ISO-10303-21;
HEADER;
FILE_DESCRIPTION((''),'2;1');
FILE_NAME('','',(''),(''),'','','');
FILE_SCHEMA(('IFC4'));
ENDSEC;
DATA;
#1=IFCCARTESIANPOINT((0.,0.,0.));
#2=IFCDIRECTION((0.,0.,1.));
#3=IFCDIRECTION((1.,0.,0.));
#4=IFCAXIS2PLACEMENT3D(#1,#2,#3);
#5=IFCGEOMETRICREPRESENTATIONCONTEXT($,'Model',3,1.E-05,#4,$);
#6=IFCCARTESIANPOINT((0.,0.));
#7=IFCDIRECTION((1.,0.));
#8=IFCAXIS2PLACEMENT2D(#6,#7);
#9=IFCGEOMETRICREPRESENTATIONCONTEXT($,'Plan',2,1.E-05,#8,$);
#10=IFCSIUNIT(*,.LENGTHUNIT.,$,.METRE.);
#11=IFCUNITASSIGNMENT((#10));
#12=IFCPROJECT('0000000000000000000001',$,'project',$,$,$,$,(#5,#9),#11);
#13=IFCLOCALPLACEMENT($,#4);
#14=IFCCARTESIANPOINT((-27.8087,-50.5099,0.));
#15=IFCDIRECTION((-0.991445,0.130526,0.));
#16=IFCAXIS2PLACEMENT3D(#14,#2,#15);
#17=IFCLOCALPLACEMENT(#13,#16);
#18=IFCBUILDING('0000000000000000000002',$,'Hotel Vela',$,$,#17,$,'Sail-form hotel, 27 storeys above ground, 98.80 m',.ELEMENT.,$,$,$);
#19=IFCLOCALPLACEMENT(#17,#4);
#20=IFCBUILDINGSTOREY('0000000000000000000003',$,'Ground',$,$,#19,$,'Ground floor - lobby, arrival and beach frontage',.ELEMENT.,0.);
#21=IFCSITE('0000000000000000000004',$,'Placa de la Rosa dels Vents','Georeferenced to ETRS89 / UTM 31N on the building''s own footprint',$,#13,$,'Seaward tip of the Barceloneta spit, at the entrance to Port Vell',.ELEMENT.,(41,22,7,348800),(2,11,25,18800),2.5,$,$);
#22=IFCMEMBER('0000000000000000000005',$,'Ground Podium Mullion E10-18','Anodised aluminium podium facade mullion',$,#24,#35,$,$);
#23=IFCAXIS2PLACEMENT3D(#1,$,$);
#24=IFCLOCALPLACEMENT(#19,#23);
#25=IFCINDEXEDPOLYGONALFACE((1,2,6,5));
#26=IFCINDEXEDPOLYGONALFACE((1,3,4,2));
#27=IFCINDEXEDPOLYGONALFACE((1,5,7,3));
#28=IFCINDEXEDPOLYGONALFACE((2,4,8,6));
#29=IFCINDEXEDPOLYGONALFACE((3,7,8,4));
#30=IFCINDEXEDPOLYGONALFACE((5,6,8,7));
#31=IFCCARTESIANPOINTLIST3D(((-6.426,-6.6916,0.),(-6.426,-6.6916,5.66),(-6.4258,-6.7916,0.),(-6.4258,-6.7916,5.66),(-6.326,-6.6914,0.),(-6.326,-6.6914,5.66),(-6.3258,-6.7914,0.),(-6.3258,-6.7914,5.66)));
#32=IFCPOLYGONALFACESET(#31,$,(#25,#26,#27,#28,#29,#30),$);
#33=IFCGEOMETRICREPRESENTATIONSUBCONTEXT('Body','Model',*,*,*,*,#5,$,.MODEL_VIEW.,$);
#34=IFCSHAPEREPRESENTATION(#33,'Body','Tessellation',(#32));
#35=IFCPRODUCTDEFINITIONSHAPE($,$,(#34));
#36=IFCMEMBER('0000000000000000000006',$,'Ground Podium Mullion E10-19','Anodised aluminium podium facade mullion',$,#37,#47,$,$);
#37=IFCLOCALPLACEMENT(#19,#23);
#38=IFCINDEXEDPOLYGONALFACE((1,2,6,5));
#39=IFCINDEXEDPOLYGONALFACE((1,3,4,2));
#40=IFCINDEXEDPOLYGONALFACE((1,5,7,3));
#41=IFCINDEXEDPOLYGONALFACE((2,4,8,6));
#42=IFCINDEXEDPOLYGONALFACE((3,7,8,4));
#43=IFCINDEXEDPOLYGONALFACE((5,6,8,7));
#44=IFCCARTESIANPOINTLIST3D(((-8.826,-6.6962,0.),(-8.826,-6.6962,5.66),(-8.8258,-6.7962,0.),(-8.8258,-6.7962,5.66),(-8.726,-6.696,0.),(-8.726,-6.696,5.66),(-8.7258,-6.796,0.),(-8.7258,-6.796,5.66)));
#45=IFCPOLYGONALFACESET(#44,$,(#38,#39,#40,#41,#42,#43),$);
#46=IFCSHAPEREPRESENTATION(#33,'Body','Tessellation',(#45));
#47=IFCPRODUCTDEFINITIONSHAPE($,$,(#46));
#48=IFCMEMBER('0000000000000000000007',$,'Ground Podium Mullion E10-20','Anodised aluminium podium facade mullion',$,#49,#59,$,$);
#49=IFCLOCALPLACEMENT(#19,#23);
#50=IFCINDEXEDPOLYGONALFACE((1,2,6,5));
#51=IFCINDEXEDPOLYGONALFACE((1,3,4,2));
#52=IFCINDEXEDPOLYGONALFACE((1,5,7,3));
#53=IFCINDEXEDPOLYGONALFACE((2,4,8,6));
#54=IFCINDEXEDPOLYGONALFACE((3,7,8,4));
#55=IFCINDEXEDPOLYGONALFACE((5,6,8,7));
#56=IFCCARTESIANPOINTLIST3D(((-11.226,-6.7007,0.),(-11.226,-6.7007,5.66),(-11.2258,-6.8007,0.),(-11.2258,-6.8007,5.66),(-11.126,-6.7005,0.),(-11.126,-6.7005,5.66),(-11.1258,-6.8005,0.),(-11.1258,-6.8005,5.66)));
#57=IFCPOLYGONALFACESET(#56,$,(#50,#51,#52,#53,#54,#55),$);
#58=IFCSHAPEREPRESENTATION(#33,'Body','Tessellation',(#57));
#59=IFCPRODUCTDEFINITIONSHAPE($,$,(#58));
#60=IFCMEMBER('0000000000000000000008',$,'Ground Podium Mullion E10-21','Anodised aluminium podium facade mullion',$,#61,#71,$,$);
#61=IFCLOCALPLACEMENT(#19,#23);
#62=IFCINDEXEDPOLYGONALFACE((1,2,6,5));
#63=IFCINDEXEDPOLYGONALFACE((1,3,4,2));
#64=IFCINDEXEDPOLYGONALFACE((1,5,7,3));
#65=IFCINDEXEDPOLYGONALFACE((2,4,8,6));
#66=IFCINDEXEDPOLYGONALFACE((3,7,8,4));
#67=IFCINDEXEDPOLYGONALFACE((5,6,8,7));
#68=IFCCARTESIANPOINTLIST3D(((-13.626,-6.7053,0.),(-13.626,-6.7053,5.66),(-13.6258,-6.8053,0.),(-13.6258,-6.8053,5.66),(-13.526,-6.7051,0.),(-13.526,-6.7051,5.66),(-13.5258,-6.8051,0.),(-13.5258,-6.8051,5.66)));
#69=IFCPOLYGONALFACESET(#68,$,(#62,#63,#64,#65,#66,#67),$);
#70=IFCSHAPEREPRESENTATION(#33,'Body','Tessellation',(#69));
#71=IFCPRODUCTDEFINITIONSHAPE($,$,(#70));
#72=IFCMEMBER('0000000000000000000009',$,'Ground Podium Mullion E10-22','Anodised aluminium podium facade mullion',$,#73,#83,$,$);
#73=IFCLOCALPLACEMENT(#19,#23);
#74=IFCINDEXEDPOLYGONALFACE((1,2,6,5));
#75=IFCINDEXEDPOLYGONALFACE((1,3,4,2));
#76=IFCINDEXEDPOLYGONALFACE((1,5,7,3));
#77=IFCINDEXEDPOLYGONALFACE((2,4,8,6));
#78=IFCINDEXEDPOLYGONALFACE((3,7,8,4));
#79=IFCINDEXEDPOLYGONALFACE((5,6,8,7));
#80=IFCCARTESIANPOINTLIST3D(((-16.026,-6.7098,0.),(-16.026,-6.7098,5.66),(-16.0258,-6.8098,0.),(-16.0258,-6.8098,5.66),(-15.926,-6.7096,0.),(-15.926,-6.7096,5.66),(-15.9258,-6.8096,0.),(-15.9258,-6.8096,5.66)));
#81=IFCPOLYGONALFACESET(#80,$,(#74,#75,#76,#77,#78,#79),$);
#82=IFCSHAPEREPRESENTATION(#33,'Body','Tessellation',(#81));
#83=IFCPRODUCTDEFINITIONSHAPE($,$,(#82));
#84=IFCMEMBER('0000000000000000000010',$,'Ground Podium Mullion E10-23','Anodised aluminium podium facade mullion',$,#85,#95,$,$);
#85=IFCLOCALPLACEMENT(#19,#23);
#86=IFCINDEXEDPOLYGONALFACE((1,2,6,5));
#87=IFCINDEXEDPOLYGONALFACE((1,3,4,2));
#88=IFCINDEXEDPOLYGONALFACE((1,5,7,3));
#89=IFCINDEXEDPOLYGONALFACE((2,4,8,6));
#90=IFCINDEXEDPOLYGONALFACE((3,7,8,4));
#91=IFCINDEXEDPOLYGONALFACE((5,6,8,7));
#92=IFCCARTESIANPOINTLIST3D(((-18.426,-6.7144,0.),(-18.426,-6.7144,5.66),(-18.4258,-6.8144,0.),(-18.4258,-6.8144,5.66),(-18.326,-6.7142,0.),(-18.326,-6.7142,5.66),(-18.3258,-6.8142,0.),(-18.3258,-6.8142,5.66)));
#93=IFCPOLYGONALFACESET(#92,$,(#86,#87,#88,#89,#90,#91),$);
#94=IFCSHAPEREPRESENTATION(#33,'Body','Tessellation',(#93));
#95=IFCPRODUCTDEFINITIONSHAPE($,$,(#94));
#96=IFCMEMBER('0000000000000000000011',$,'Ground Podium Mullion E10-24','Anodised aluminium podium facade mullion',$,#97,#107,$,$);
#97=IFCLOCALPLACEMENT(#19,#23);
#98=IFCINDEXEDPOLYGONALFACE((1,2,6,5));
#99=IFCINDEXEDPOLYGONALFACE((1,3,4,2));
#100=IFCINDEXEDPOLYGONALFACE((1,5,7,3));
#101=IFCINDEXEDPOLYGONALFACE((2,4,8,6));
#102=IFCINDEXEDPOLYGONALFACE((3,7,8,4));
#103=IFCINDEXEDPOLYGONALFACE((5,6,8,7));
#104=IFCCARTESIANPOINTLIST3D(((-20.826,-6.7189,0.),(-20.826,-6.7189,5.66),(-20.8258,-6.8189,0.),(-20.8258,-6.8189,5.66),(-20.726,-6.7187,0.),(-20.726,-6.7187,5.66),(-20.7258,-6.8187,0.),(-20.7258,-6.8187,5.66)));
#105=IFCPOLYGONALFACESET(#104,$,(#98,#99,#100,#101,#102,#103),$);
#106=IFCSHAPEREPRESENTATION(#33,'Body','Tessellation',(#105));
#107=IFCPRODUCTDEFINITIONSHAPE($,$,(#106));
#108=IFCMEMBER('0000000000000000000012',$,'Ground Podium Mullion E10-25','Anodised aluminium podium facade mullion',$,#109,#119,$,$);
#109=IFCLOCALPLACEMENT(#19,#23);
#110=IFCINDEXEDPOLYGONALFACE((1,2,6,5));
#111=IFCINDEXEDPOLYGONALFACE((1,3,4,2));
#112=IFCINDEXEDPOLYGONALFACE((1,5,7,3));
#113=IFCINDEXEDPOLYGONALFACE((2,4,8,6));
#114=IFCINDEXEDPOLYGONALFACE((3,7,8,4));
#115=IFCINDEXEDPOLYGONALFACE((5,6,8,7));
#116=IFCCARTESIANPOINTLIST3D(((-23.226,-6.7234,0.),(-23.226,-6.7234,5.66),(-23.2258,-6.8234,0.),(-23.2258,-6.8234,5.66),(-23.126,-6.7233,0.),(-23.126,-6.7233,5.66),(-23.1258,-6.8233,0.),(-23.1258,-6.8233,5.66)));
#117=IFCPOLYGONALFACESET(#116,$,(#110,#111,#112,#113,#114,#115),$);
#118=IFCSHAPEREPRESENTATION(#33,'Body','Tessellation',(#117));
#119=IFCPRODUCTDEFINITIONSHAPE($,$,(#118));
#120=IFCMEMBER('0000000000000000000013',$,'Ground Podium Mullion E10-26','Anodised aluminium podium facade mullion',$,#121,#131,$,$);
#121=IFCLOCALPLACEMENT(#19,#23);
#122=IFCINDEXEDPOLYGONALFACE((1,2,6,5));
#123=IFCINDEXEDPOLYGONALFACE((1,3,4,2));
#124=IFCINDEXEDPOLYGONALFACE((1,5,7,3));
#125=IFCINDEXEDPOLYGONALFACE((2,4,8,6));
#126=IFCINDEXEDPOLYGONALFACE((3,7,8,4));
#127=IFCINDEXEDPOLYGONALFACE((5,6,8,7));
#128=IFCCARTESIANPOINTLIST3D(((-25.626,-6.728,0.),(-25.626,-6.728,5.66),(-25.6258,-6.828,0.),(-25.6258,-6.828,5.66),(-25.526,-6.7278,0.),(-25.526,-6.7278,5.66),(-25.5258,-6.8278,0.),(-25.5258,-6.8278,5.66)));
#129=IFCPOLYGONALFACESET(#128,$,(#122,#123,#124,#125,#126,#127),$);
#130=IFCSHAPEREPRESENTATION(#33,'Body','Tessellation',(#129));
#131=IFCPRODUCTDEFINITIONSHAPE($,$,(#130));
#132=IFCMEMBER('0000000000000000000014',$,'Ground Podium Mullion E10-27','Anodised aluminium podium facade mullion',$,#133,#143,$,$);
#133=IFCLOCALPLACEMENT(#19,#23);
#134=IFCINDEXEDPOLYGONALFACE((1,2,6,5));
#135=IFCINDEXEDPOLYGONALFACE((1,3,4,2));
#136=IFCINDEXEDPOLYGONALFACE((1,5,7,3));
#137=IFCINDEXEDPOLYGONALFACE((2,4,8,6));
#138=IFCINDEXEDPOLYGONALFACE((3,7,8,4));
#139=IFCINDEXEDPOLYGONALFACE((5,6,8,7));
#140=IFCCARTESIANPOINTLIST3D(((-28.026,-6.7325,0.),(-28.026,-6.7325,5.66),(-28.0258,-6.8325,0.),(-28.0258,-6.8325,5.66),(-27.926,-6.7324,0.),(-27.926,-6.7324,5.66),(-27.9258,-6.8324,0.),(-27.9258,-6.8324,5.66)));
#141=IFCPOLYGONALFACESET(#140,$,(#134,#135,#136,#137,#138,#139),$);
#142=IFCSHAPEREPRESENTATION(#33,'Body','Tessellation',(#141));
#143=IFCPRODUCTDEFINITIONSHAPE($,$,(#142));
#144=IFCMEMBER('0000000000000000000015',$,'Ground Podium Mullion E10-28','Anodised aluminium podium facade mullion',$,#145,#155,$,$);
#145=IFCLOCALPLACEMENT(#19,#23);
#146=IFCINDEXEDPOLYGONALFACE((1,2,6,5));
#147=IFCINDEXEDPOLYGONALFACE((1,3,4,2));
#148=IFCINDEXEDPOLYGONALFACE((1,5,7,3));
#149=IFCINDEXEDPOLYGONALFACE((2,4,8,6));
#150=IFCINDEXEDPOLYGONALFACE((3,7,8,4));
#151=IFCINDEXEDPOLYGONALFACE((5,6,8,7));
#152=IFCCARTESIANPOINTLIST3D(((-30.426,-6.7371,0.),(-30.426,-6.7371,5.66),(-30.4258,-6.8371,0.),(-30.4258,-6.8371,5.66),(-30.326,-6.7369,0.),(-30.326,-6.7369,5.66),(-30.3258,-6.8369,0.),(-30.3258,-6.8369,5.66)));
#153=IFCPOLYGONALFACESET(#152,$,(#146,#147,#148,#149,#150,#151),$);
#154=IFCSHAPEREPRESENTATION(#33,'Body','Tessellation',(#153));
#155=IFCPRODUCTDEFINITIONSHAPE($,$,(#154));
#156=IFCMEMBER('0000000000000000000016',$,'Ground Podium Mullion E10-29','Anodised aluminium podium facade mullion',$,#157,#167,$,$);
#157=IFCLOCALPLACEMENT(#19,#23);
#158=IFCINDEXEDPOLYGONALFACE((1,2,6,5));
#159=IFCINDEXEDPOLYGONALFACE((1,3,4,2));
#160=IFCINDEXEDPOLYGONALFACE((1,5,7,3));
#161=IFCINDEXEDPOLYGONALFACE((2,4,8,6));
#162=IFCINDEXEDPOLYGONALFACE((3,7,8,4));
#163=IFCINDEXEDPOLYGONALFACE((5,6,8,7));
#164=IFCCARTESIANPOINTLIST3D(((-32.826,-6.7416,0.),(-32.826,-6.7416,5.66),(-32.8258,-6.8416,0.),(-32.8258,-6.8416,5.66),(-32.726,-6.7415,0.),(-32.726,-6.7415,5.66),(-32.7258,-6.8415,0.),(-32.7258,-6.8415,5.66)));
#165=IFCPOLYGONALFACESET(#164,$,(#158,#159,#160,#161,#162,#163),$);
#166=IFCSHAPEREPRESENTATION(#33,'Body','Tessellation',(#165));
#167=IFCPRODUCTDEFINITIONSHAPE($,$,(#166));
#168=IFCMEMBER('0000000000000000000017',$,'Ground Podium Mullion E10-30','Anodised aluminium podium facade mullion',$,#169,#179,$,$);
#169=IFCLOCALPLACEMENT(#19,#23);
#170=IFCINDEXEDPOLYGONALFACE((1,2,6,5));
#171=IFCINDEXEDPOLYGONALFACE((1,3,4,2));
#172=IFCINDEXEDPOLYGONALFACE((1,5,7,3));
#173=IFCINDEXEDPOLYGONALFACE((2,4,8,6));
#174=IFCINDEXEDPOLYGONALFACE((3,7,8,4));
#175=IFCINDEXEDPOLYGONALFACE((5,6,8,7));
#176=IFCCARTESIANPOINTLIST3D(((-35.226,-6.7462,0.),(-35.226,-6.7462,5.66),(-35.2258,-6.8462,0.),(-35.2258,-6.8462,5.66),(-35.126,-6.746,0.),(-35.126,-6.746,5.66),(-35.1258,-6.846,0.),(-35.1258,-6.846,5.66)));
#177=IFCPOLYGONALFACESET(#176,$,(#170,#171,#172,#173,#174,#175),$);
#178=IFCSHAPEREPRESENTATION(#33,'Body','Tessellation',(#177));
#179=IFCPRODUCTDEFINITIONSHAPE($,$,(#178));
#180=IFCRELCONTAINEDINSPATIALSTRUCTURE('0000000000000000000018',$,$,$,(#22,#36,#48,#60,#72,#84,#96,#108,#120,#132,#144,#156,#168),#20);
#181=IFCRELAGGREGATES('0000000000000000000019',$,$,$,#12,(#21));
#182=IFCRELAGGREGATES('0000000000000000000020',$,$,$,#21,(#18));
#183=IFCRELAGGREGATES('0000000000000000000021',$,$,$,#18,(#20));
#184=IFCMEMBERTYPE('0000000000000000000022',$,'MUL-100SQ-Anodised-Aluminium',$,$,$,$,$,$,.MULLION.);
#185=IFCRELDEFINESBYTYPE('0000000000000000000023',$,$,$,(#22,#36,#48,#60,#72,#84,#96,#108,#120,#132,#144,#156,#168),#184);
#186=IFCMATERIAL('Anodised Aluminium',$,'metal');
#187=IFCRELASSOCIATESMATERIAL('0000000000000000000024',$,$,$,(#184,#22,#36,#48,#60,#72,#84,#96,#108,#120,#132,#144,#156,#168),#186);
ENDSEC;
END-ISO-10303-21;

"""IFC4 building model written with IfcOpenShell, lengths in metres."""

from ifc_helpers import new_model, si_unit, frame, origin_with_axes, origin_2d_with_axis, place, context, subcontext, project, spatial, line, indexed_curve, rectangle, outline, extrude, material, material_profile, profile_set, profile_usage, type_object, element, save


model = new_model("IFC4")

# Units and contexts
model_context = context("Model", 3, precision=1e-05, world=origin_with_axes())
plan_context = context("Plan", 2, precision=1e-05, world=origin_2d_with_axis())
body_context = subcontext(model_context, "Body", "Model", "MODEL_VIEW")
ifc_project = project(units=[si_unit("LENGTHUNIT", "METRE")], contexts=[model_context, plan_context])

# Site, building, storey
site_placement = place(None, origin_with_axes())
site = spatial("IfcSite", under=ifc_project, at=site_placement, Name="Placa de la Rosa dels Vents", Description="Georeferenced to ETRS89 / UTM 31N on the building's own footprint", LongName="Seaward tip of the Barceloneta spit, at the entrance to Port Vell", CompositionType="ELEMENT", RefLatitude=(41, 22, 7, 348800), RefLongitude=(2, 11, 25, 18800), RefElevation=2.5)
building_placement = place(site_placement, frame((-27.8087, -50.5099, 0.0), z_axis=(0.0, 0.0, 1.0), x_axis=(-0.991445, 0.130526, 0.0)))
building = spatial("IfcBuilding", under=site, at=building_placement, Name="Hotel Vela", LongName="Sail-form hotel, 27 storeys above ground, 98.80 m", CompositionType="ELEMENT")
storey_placement = place(building_placement, origin_with_axes())
storey = spatial("IfcBuildingStorey", under=building, at=storey_placement, Name="Ground", LongName="Ground floor - lobby, arrival and beach frontage", CompositionType="ELEMENT", Elevation=0.0)

# Members
ifc_material_1 = material(Name="Anodised Aluminium", Category="metal")
ifc_material_profile = material_profile(ifc_material_1, rectangle(XDim=0.1, YDim=0.1))
ifc_profile_set = profile_set([ifc_material_profile], Name="MUL-100SQ-Anodised-Aluminium")
ifc_profile_usage_1 = profile_usage(ifc_profile_set)
member_type = type_object("IfcMemberType", Name="MUL-100SQ-Anodised-Aluminium", PredefinedType="MULLION", material=ifc_profile_set)
member_1_placement = place(storey_placement, frame((-6.326, -6.6914, 0.0), z_axis=(0.0, 0.0, 1.0), x_axis=(-0.999998, -0.001895, 0.0)))
element("IfcMember", 1, at=member_1_placement, inside=storey, type_object=member_type, material=ifc_profile_usage_1, Name="Ground Podium Mullion E10-18", Description="Anodised aluminium podium facade mullion", context=body_context, shape_type="SweptSolid", body=[
    extrude(outline(indexed_curve([(0.0, 0.0), (0.1, 0.0), (0.1, 0.1), (0.0, 0.1)], segments=[line(1, 2, 3, 4, 1)])), origin_with_axes(), (0.0, 0.0, 1.0), 5.66),
])
ifc_profile_usage_2 = profile_usage(ifc_profile_set)
member_2_placement = place(storey_placement, frame((-8.726, -6.696, 0.0), z_axis=(0.0, 0.0, 1.0), x_axis=(-0.999998, -0.001895, 0.0)))
element("IfcMember", 2, at=member_2_placement, inside=storey, type_object=member_type, material=ifc_profile_usage_2, Name="Ground Podium Mullion E10-19", Description="Anodised aluminium podium facade mullion", context=body_context, shape_type="SweptSolid", body=[
    extrude(outline(indexed_curve([(0.0, 0.0), (0.1, 0.0), (0.1, 0.1), (0.0, 0.1)], segments=[line(1, 2, 3, 4, 1)])), origin_with_axes(), (0.0, 0.0, 1.0), 5.66),
])
ifc_profile_usage_3 = profile_usage(ifc_profile_set)
member_3_placement = place(storey_placement, frame((-11.126, -6.7005, 0.0), z_axis=(0.0, 0.0, 1.0), x_axis=(-0.999998, -0.001895, 0.0)))
element("IfcMember", 3, at=member_3_placement, inside=storey, type_object=member_type, material=ifc_profile_usage_3, Name="Ground Podium Mullion E10-20", Description="Anodised aluminium podium facade mullion", context=body_context, shape_type="SweptSolid", body=[
    extrude(outline(indexed_curve([(0.0, 0.0), (0.1, 0.0), (0.1, 0.1), (0.0, 0.1)], segments=[line(1, 2, 3, 4, 1)])), origin_with_axes(), (0.0, 0.0, 1.0), 5.66),
])
ifc_profile_usage_4 = profile_usage(ifc_profile_set)
member_4_placement = place(storey_placement, frame((-13.526, -6.7051, 0.0), z_axis=(0.0, 0.0, 1.0), x_axis=(-0.999998, -0.001895, 0.0)))
element("IfcMember", 4, at=member_4_placement, inside=storey, type_object=member_type, material=ifc_profile_usage_4, Name="Ground Podium Mullion E10-21", Description="Anodised aluminium podium facade mullion", context=body_context, shape_type="SweptSolid", body=[
    extrude(outline(indexed_curve([(0.0, 0.0), (0.1, 0.0), (0.1, 0.1), (0.0, 0.1)], segments=[line(1, 2, 3, 4, 1)])), origin_with_axes(), (0.0, 0.0, 1.0), 5.66),
])
ifc_profile_usage_5 = profile_usage(ifc_profile_set)
member_5_placement = place(storey_placement, frame((-15.926, -6.7096, 0.0), z_axis=(0.0, 0.0, 1.0), x_axis=(-0.999998, -0.001895, 0.0)))
element("IfcMember", 5, at=member_5_placement, inside=storey, type_object=member_type, material=ifc_profile_usage_5, Name="Ground Podium Mullion E10-22", Description="Anodised aluminium podium facade mullion", context=body_context, shape_type="SweptSolid", body=[
    extrude(outline(indexed_curve([(0.0, 0.0), (0.1, 0.0), (0.1, 0.1), (0.0, 0.1)], segments=[line(1, 2, 3, 4, 1)])), origin_with_axes(), (0.0, 0.0, 1.0), 5.66),
])
ifc_profile_usage_6 = profile_usage(ifc_profile_set)
member_6_placement = place(storey_placement, frame((-18.326, -6.7142, 0.0), z_axis=(0.0, 0.0, 1.0), x_axis=(-0.999998, -0.001895, 0.0)))
element("IfcMember", 6, at=member_6_placement, inside=storey, type_object=member_type, material=ifc_profile_usage_6, Name="Ground Podium Mullion E10-23", Description="Anodised aluminium podium facade mullion", context=body_context, shape_type="SweptSolid", body=[
    extrude(outline(indexed_curve([(0.0, 0.0), (0.1, 0.0), (0.1, 0.1), (0.0, 0.1)], segments=[line(1, 2, 3, 4, 1)])), origin_with_axes(), (0.0, 0.0, 1.0), 5.66),
])
ifc_profile_usage_7 = profile_usage(ifc_profile_set)
member_7_placement = place(storey_placement, frame((-20.726, -6.7187, 0.0), z_axis=(0.0, 0.0, 1.0), x_axis=(-0.999998, -0.001895, 0.0)))
element("IfcMember", 7, at=member_7_placement, inside=storey, type_object=member_type, material=ifc_profile_usage_7, Name="Ground Podium Mullion E10-24", Description="Anodised aluminium podium facade mullion", context=body_context, shape_type="SweptSolid", body=[
    extrude(outline(indexed_curve([(0.0, 0.0), (0.1, 0.0), (0.1, 0.1), (0.0, 0.1)], segments=[line(1, 2, 3, 4, 1)])), origin_with_axes(), (0.0, 0.0, 1.0), 5.66),
])
ifc_profile_usage_8 = profile_usage(ifc_profile_set)
member_8_placement = place(storey_placement, frame((-23.126, -6.7233, 0.0), z_axis=(0.0, 0.0, 1.0), x_axis=(-0.999998, -0.001895, 0.0)))
element("IfcMember", 8, at=member_8_placement, inside=storey, type_object=member_type, material=ifc_profile_usage_8, Name="Ground Podium Mullion E10-25", Description="Anodised aluminium podium facade mullion", context=body_context, shape_type="SweptSolid", body=[
    extrude(outline(indexed_curve([(0.0, 0.0), (0.1, 0.0), (0.1, 0.1), (0.0, 0.1)], segments=[line(1, 2, 3, 4, 1)])), origin_with_axes(), (0.0, 0.0, 1.0), 5.66),
])
ifc_profile_usage_9 = profile_usage(ifc_profile_set)
member_9_placement = place(storey_placement, frame((-25.526, -6.7278, 0.0), z_axis=(0.0, 0.0, 1.0), x_axis=(-0.999998, -0.001895, 0.0)))
element("IfcMember", 9, at=member_9_placement, inside=storey, type_object=member_type, material=ifc_profile_usage_9, Name="Ground Podium Mullion E10-26", Description="Anodised aluminium podium facade mullion", context=body_context, shape_type="SweptSolid", body=[
    extrude(outline(indexed_curve([(0.0, 0.0), (0.1, 0.0), (0.1, 0.1), (0.0, 0.1)], segments=[line(1, 2, 3, 4, 1)])), origin_with_axes(), (0.0, 0.0, 1.0), 5.66),
])
ifc_profile_usage_10 = profile_usage(ifc_profile_set)
member_10_placement = place(storey_placement, frame((-27.926, -6.7324, 0.0), z_axis=(0.0, 0.0, 1.0), x_axis=(-0.999998, -0.001895, 0.0)))
element("IfcMember", 10, at=member_10_placement, inside=storey, type_object=member_type, material=ifc_profile_usage_10, Name="Ground Podium Mullion E10-27", Description="Anodised aluminium podium facade mullion", context=body_context, shape_type="SweptSolid", body=[
    extrude(outline(indexed_curve([(0.0, 0.0), (0.1, 0.0), (0.1, 0.1), (0.0, 0.1)], segments=[line(1, 2, 3, 4, 1)])), origin_with_axes(), (0.0, 0.0, 1.0), 5.66),
])
ifc_profile_usage_11 = profile_usage(ifc_profile_set)
member_11_placement = place(storey_placement, frame((-30.326, -6.7369, 0.0), z_axis=(0.0, 0.0, 1.0), x_axis=(-0.999998, -0.001895, 0.0)))
element("IfcMember", 11, at=member_11_placement, inside=storey, type_object=member_type, material=ifc_profile_usage_11, Name="Ground Podium Mullion E10-28", Description="Anodised aluminium podium facade mullion", context=body_context, shape_type="SweptSolid", body=[
    extrude(outline(indexed_curve([(0.0, 0.0), (0.1, 0.0), (0.1, 0.1), (0.0, 0.1)], segments=[line(1, 2, 3, 4, 1)])), origin_with_axes(), (0.0, 0.0, 1.0), 5.66),
])
ifc_profile_usage_12 = profile_usage(ifc_profile_set)
member_12_placement = place(storey_placement, frame((-32.726, -6.7415, 0.0), z_axis=(0.0, 0.0, 1.0), x_axis=(-0.999998, -0.001895, 0.0)))
element("IfcMember", 12, at=member_12_placement, inside=storey, type_object=member_type, material=ifc_profile_usage_12, Name="Ground Podium Mullion E10-29", Description="Anodised aluminium podium facade mullion", context=body_context, shape_type="SweptSolid", body=[
    extrude(outline(indexed_curve([(0.0, 0.0), (0.1, 0.0), (0.1, 0.1), (0.0, 0.1)], segments=[line(1, 2, 3, 4, 1)])), origin_with_axes(), (0.0, 0.0, 1.0), 5.66),
])
ifc_profile_usage_13 = profile_usage(ifc_profile_set)
member_13_placement = place(storey_placement, frame((-35.126, -6.746, 0.0), z_axis=(0.0, 0.0, 1.0), x_axis=(-0.999998, -0.001895, 0.0)))
element("IfcMember", 13, at=member_13_placement, inside=storey, type_object=member_type, material=ifc_profile_usage_13, Name="Ground Podium Mullion E10-30", Description="Anodised aluminium podium facade mullion", context=body_context, shape_type="SweptSolid", body=[
    extrude(outline(indexed_curve([(0.0, 0.0), (0.1, 0.0), (0.1, 0.1), (0.0, 0.1)], segments=[line(1, 2, 3, 4, 1)])), origin_with_axes(), (0.0, 0.0, 1.0), 5.66),
])

save(model, "model.ifc")
